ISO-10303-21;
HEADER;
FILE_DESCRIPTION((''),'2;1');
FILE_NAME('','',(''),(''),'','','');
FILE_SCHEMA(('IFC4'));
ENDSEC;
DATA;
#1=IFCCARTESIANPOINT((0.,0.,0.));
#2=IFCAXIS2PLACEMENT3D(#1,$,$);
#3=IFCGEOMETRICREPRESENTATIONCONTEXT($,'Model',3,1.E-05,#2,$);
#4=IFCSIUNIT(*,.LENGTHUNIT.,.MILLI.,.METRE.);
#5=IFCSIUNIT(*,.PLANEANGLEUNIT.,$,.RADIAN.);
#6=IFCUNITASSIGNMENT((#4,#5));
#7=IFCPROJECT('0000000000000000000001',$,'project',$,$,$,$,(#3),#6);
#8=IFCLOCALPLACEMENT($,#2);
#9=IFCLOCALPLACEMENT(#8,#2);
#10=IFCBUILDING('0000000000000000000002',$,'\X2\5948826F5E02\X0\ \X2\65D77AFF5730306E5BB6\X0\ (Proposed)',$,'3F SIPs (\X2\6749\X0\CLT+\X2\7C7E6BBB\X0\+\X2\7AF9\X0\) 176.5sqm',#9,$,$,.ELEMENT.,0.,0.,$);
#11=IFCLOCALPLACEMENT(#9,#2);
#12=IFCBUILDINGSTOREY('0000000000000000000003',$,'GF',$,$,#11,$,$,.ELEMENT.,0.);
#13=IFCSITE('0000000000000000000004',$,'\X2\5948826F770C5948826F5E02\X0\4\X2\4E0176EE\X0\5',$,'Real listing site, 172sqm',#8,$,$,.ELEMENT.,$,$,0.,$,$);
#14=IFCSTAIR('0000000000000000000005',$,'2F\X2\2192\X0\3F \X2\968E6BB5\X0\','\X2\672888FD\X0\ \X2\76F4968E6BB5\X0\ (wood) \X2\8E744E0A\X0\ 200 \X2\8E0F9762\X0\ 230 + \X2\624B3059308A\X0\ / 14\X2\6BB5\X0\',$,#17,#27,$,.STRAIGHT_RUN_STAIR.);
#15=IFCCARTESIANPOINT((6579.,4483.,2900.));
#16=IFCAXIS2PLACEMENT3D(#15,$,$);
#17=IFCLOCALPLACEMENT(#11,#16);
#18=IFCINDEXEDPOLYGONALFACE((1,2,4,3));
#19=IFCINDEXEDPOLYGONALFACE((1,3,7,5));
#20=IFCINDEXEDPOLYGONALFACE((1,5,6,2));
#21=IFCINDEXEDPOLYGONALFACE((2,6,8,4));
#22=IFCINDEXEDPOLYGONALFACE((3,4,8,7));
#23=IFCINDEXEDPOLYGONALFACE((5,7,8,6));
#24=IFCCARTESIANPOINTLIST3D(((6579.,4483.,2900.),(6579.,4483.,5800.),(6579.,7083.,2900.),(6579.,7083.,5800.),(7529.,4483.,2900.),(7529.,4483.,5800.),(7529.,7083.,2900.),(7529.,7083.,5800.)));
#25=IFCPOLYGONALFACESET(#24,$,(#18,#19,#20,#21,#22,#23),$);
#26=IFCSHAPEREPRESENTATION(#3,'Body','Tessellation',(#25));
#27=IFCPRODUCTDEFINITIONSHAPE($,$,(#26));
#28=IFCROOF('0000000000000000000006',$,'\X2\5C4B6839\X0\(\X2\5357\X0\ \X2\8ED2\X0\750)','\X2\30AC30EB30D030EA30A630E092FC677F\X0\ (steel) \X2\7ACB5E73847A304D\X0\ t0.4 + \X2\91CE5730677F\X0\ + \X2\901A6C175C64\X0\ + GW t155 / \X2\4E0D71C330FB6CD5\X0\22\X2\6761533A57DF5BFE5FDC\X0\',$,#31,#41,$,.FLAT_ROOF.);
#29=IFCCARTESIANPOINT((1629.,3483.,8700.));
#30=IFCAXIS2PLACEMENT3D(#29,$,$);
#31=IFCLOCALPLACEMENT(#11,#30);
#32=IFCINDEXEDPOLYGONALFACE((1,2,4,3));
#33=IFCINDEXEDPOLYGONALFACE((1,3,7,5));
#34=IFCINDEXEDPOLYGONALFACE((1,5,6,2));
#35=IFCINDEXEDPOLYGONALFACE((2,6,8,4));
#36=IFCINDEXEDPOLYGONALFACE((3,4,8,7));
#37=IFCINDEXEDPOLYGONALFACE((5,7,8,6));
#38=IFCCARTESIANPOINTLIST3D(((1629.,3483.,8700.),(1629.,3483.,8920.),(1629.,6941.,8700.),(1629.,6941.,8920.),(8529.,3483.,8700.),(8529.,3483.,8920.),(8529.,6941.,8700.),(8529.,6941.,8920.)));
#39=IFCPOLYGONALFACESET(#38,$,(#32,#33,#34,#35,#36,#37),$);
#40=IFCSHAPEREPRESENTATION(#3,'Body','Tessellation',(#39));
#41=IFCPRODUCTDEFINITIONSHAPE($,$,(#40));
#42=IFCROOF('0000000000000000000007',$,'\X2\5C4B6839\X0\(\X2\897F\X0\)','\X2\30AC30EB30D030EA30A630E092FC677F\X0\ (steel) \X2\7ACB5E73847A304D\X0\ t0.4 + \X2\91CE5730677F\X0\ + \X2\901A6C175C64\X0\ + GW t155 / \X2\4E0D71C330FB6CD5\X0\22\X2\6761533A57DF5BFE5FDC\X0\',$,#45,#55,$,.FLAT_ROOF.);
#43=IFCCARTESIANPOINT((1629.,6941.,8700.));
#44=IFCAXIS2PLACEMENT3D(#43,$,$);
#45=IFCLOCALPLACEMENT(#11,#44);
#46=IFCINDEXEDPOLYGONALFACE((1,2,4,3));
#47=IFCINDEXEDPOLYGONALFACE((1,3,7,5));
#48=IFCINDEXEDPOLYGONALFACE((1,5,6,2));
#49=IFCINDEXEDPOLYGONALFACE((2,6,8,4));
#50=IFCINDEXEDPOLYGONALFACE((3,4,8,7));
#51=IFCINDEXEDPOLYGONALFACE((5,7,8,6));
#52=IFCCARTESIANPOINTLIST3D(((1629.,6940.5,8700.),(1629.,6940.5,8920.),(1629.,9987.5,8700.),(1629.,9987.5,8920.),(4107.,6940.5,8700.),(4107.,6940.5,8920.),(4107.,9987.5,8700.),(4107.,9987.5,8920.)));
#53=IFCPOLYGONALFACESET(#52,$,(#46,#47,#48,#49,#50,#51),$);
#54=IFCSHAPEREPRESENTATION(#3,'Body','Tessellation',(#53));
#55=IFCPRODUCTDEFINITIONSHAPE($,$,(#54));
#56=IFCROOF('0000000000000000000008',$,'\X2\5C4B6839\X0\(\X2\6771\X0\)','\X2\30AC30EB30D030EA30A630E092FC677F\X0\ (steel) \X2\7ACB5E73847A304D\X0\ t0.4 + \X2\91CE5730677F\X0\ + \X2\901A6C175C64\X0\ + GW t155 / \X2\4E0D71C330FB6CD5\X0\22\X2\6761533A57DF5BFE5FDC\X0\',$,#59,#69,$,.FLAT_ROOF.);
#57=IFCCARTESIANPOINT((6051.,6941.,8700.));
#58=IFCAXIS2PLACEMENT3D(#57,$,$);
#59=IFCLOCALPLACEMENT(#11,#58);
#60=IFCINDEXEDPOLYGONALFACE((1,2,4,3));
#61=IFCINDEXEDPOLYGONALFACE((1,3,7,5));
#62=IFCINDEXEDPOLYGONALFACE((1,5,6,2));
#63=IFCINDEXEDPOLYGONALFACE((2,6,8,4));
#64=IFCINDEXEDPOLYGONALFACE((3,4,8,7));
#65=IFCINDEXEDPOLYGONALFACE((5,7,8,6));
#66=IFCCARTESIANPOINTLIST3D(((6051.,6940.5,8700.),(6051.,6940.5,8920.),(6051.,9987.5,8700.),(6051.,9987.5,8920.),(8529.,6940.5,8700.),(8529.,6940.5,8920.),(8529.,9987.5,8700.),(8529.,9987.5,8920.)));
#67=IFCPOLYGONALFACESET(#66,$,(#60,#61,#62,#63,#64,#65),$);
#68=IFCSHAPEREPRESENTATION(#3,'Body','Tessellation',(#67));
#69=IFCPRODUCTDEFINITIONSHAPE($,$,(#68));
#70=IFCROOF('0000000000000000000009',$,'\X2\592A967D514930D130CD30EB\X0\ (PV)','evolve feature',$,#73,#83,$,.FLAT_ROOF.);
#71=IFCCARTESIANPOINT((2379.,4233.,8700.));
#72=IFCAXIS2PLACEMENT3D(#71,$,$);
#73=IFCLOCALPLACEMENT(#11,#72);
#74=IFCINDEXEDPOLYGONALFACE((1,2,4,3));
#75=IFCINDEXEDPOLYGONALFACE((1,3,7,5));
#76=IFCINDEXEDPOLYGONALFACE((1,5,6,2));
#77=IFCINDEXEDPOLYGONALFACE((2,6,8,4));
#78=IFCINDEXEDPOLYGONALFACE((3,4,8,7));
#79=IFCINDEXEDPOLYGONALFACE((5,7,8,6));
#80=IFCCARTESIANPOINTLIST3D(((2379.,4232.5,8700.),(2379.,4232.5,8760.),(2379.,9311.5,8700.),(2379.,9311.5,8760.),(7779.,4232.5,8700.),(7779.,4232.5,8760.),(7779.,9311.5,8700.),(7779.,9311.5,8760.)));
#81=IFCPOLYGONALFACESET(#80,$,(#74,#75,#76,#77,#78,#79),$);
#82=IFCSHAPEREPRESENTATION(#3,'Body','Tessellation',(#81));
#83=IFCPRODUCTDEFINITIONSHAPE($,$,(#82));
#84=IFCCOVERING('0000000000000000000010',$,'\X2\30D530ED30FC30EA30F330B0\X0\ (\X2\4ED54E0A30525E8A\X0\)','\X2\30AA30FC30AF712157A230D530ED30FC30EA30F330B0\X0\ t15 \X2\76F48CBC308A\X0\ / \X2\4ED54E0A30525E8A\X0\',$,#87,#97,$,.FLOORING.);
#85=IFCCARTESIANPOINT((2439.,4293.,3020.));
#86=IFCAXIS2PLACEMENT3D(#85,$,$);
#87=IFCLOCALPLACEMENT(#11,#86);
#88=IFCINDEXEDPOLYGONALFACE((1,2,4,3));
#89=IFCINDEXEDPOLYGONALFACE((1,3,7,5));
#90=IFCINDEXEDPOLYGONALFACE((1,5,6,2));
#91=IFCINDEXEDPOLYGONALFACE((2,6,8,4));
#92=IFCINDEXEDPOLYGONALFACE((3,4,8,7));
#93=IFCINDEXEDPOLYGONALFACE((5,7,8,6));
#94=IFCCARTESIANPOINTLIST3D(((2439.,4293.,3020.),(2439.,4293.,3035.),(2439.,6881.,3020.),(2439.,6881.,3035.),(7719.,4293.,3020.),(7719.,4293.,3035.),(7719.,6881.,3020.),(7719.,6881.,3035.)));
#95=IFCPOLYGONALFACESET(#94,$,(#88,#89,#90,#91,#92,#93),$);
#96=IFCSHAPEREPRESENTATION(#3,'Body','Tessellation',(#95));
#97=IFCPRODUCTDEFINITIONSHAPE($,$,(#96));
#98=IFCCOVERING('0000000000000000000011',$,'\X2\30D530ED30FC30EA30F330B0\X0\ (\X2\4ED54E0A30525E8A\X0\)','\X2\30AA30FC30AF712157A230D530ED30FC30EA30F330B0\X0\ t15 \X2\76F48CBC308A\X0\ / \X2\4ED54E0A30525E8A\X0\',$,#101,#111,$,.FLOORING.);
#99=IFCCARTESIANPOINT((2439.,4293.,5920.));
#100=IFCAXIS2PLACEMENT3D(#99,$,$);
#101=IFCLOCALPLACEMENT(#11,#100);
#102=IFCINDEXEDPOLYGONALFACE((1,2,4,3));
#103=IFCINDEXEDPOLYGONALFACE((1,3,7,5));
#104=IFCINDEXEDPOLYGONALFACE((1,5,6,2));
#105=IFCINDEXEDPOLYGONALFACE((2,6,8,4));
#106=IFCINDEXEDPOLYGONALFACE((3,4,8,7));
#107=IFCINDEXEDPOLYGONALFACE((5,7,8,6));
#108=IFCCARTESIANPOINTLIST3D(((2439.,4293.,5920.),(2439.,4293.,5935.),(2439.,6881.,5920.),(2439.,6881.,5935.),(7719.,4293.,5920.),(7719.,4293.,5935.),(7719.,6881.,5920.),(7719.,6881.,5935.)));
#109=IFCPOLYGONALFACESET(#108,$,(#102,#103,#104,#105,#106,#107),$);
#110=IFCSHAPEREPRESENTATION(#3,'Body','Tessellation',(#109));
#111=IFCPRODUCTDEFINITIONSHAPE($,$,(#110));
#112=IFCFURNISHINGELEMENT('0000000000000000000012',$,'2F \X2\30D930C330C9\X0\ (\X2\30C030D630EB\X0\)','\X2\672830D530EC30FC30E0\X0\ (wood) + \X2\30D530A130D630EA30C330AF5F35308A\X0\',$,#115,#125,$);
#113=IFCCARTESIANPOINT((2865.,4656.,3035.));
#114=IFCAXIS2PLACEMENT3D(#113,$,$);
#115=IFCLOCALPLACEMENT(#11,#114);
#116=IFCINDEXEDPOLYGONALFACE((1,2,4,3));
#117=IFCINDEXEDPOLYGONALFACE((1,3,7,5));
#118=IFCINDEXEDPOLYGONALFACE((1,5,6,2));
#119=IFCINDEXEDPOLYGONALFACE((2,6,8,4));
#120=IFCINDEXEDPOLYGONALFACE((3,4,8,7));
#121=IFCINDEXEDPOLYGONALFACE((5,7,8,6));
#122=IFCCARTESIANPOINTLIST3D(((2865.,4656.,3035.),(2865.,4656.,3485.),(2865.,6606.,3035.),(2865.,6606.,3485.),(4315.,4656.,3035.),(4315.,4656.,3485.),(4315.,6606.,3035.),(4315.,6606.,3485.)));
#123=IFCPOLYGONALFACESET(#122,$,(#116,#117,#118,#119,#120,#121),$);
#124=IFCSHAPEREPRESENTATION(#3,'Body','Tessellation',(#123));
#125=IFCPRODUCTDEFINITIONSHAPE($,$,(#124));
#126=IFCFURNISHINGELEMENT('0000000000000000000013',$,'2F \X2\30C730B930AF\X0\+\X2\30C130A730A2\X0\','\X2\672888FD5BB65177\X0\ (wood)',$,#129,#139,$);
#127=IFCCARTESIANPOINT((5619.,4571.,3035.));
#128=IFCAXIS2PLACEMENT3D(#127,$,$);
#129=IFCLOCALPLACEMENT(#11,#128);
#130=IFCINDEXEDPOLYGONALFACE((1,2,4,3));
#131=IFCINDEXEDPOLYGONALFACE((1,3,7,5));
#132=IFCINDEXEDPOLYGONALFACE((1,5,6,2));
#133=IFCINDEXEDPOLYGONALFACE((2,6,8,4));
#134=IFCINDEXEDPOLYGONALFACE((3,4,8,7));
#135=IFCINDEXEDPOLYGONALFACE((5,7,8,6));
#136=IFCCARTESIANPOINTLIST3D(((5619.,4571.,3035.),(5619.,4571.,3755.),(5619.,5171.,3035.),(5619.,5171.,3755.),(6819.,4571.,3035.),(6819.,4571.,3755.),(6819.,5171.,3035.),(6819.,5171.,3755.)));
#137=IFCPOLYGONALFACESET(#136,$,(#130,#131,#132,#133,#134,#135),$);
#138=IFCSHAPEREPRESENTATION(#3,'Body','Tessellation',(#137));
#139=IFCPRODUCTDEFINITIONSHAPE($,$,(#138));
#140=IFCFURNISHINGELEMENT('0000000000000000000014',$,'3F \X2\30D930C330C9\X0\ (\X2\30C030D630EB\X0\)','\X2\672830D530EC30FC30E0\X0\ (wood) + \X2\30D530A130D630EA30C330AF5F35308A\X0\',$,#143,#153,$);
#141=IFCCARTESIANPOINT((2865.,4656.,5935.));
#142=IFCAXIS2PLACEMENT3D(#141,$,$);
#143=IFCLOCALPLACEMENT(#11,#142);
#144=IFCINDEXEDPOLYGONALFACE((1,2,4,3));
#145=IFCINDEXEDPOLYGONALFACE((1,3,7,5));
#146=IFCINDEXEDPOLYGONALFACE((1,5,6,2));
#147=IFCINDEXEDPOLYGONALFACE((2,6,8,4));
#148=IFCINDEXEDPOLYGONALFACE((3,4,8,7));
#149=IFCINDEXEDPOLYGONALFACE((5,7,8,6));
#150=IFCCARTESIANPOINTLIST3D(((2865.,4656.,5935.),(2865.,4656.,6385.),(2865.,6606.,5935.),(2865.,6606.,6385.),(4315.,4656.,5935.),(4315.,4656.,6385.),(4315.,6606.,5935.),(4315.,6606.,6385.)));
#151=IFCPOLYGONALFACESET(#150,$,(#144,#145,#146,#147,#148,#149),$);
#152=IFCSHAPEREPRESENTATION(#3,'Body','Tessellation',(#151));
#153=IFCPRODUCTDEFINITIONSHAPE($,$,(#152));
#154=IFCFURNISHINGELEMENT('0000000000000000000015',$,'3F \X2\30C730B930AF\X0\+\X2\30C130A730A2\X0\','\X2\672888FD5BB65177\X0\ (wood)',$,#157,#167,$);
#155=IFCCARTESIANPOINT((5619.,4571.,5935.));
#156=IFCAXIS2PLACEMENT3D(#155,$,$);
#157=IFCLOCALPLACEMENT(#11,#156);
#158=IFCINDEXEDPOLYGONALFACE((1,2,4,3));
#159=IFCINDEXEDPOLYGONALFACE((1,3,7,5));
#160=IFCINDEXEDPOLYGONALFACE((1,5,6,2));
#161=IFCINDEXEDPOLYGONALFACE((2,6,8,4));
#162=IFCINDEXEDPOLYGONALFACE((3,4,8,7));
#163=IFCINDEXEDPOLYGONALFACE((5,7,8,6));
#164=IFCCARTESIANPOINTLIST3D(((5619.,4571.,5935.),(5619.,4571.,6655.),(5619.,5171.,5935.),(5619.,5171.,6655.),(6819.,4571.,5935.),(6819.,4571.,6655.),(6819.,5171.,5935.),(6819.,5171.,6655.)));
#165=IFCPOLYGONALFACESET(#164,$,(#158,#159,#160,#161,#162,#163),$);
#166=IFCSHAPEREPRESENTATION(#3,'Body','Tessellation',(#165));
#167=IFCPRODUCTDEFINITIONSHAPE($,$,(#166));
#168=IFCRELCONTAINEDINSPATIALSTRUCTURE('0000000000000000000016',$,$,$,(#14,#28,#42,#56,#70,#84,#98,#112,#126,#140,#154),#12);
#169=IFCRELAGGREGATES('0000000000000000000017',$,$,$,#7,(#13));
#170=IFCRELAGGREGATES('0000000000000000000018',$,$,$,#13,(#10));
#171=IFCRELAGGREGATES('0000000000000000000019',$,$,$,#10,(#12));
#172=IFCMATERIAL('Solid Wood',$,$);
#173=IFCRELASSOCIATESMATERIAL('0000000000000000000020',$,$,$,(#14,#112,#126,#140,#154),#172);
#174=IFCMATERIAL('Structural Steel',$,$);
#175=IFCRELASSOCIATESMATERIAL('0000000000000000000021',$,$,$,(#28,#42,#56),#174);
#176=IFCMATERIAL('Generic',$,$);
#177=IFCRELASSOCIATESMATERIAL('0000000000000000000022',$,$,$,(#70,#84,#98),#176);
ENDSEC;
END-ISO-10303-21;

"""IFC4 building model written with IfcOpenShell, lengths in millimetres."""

from ifc_helpers import new_model, si_unit, frame, frame_2d, origin, place, context, project, spatial, rectangle, extrude, material, element, save


model = new_model("IFC4")

# Units and contexts
model_context = context("Model", 3, precision=1e-05, world=origin())
ifc_project = project(units=[si_unit("LENGTHUNIT", "METRE", prefix="MILLI"), si_unit("PLANEANGLEUNIT", "RADIAN")], contexts=[model_context])

# Site, building, storey
site_placement = place(None, origin())
site = spatial("IfcSite", under=ifc_project, at=site_placement, Name="奈良県奈良市4丁目5", ObjectType="Real listing site, 172sqm", CompositionType="ELEMENT", RefElevation=0.0)
building_placement = place(site_placement, origin())
building = spatial("IfcBuilding", under=site, at=building_placement, Name="奈良市 旗竿地の家 (Proposed)", ObjectType="3F SIPs (杉CLT+籾殻+竹) 176.5sqm", CompositionType="ELEMENT", ElevationOfRefHeight=0.0, ElevationOfTerrain=0.0)
storey_placement = place(building_placement, origin())
storey = spatial("IfcBuildingStorey", under=building, at=storey_placement, Name="GF", CompositionType="ELEMENT", Elevation=0.0)

# Shared definitions
ifc_material_1 = material(Name="Solid Wood")

# Stair
stair_placement = place(storey_placement, frame((6579.0, 4483.0, 2900.0)))
element("IfcStair", 1, at=stair_placement, inside=storey, material=ifc_material_1, Name="2F→3F 階段", Description="木製 直階段 (wood) 蹴上 200 踏面 230 + 手すり / 14段", PredefinedType="STRAIGHT_RUN_STAIR", context=model_context, shape_type="SweptSolid", body=[
    extrude(rectangle(XDim=950.0, YDim=2600.0, at=frame_2d((475.0, 1300.0))), frame((6579.0, 4483.0, 2900.0)), (0.0, 0.0, 1.0), 2900.0),
])

# Roofs
ifc_material_2 = material(Name="Structural Steel")
roof_1_placement = place(storey_placement, frame((1629.0, 3483.0, 8700.0)))
element("IfcRoof", 2, at=roof_1_placement, inside=storey, material=ifc_material_2, Name="屋根(南 軒750)", Description="ガルバリウム鋼板 (steel) 立平葺き t0.4 + 野地板 + 通気層 + GW t155 / 不燃・法22条区域対応", PredefinedType="FLAT_ROOF", context=model_context, shape_type="SweptSolid", body=[
    extrude(rectangle(XDim=6900.0, YDim=3458.0, at=frame_2d((3450.0, 1729.0))), frame((1629.0, 3483.0, 8700.0)), (0.0, 0.0, 1.0), 220.0),
])
roof_2_placement = place(storey_placement, frame((1629.0, 6941.0, 8700.0)))
element("IfcRoof", 3, at=roof_2_placement, inside=storey, material=ifc_material_2, Name="屋根(西)", Description="ガルバリウム鋼板 (steel) 立平葺き t0.4 + 野地板 + 通気層 + GW t155 / 不燃・法22条区域対応", PredefinedType="FLAT_ROOF", context=model_context, shape_type="SweptSolid", body=[
    extrude(rectangle(XDim=2478.0, YDim=3047.0, at=frame_2d((1239.0, 1523.0))), frame((1629.0, 6941.0, 8700.0)), (0.0, 0.0, 1.0), 220.0),
])
roof_3_placement = place(storey_placement, frame((6051.0, 6941.0, 8700.0)))
element("IfcRoof", 4, at=roof_3_placement, inside=storey, material=ifc_material_2, Name="屋根(東)", Description="ガルバリウム鋼板 (steel) 立平葺き t0.4 + 野地板 + 通気層 + GW t155 / 不燃・法22条区域対応", PredefinedType="FLAT_ROOF", context=model_context, shape_type="SweptSolid", body=[
    extrude(rectangle(XDim=2478.0, YDim=3047.0, at=frame_2d((1239.0, 1523.0))), frame((6051.0, 6941.0, 8700.0)), (0.0, 0.0, 1.0), 220.0),
])
ifc_material_3 = material(Name="Generic")
roof_4_placement = place(storey_placement, frame((2379.0, 4233.0, 8700.0)))
element("IfcRoof", 5, at=roof_4_placement, inside=storey, material=ifc_material_3, Name="太陽光パネル (PV)", Description="evolve feature", PredefinedType="FLAT_ROOF", context=model_context, shape_type="SweptSolid", body=[
    extrude(rectangle(XDim=5400.0, YDim=5079.0, at=frame_2d((2700.0, 2539.0))), frame((2379.0, 4233.0, 8700.0)), (0.0, 0.0, 1.0), 60.0),
])

# Coverings
covering_1_placement = place(storey_placement, frame((2439.0, 4293.0, 3020.0)))
element("IfcCovering", 6, at=covering_1_placement, inside=storey, material=ifc_material_3, Name="フローリング (仕上げ床)", Description="オーク無垢フローリング t15 直貼り / 仕上げ床", PredefinedType="FLOORING", context=model_context, shape_type="SweptSolid", body=[
    extrude(rectangle(XDim=5280.0, YDim=2588.0, at=frame_2d((2640.0, 1294.0))), frame((2439.0, 4293.0, 3020.0)), (0.0, 0.0, 1.0), 15.0),
])
covering_2_placement = place(storey_placement, frame((2439.0, 4293.0, 5920.0)))
element("IfcCovering", 7, at=covering_2_placement, inside=storey, material=ifc_material_3, Name="フローリング (仕上げ床)", Description="オーク無垢フローリング t15 直貼り / 仕上げ床", PredefinedType="FLOORING", context=model_context, shape_type="SweptSolid", body=[
    extrude(rectangle(XDim=5280.0, YDim=2588.0, at=frame_2d((2640.0, 1294.0))), frame((2439.0, 4293.0, 5920.0)), (0.0, 0.0, 1.0), 15.0),
])

# Furnishing elements
furnishing_1_placement = place(storey_placement, frame((2865.0, 4656.0, 3035.0)))
element("IfcFurnishingElement", 8, at=furnishing_1_placement, inside=storey, material=ifc_material_1, Name="2F ベッド (ダブル)", Description="木フレーム (wood) + ファブリック張り", context=model_context, shape_type="SweptSolid", body=[
    extrude(rectangle(XDim=1450.0, YDim=1950.0, at=frame_2d((725.0, 975.0))), frame((2865.0, 4656.0, 3035.0)), (0.0, 0.0, 1.0), 450.0),
])
furnishing_2_placement = place(storey_placement, frame((5619.0, 4571.0, 3035.0)))
element("IfcFurnishingElement", 9, at=furnishing_2_placement, inside=storey, material=ifc_material_1, Name="2F デスク+チェア", Description="木製家具 (wood)", context=model_context, shape_type="SweptSolid", body=[
    extrude(rectangle(XDim=1200.0, YDim=600.0, at=frame_2d((600.0, 300.0))), frame((5619.0, 4571.0, 3035.0)), (0.0, 0.0, 1.0), 720.0),
])
furnishing_3_placement = place(storey_placement, frame((2865.0, 4656.0, 5935.0)))
element("IfcFurnishingElement", 10, at=furnishing_3_placement, inside=storey, material=ifc_material_1, Name="3F ベッド (ダブル)", Description="木フレーム (wood) + ファブリック張り", context=model_context, shape_type="SweptSolid", body=[
    extrude(rectangle(XDim=1450.0, YDim=1950.0, at=frame_2d((725.0, 975.0))), frame((2865.0, 4656.0, 5935.0)), (0.0, 0.0, 1.0), 450.0),
])
furnishing_4_placement = place(storey_placement, frame((5619.0, 4571.0, 5935.0)))
element("IfcFurnishingElement", 11, at=furnishing_4_placement, inside=storey, material=ifc_material_1, Name="3F デスク+チェア", Description="木製家具 (wood)", context=model_context, shape_type="SweptSolid", body=[
    extrude(rectangle(XDim=1200.0, YDim=600.0, at=frame_2d((600.0, 300.0))), frame((5619.0, 4571.0, 5935.0)), (0.0, 0.0, 1.0), 720.0),
])

save(model, "model.ifc")
